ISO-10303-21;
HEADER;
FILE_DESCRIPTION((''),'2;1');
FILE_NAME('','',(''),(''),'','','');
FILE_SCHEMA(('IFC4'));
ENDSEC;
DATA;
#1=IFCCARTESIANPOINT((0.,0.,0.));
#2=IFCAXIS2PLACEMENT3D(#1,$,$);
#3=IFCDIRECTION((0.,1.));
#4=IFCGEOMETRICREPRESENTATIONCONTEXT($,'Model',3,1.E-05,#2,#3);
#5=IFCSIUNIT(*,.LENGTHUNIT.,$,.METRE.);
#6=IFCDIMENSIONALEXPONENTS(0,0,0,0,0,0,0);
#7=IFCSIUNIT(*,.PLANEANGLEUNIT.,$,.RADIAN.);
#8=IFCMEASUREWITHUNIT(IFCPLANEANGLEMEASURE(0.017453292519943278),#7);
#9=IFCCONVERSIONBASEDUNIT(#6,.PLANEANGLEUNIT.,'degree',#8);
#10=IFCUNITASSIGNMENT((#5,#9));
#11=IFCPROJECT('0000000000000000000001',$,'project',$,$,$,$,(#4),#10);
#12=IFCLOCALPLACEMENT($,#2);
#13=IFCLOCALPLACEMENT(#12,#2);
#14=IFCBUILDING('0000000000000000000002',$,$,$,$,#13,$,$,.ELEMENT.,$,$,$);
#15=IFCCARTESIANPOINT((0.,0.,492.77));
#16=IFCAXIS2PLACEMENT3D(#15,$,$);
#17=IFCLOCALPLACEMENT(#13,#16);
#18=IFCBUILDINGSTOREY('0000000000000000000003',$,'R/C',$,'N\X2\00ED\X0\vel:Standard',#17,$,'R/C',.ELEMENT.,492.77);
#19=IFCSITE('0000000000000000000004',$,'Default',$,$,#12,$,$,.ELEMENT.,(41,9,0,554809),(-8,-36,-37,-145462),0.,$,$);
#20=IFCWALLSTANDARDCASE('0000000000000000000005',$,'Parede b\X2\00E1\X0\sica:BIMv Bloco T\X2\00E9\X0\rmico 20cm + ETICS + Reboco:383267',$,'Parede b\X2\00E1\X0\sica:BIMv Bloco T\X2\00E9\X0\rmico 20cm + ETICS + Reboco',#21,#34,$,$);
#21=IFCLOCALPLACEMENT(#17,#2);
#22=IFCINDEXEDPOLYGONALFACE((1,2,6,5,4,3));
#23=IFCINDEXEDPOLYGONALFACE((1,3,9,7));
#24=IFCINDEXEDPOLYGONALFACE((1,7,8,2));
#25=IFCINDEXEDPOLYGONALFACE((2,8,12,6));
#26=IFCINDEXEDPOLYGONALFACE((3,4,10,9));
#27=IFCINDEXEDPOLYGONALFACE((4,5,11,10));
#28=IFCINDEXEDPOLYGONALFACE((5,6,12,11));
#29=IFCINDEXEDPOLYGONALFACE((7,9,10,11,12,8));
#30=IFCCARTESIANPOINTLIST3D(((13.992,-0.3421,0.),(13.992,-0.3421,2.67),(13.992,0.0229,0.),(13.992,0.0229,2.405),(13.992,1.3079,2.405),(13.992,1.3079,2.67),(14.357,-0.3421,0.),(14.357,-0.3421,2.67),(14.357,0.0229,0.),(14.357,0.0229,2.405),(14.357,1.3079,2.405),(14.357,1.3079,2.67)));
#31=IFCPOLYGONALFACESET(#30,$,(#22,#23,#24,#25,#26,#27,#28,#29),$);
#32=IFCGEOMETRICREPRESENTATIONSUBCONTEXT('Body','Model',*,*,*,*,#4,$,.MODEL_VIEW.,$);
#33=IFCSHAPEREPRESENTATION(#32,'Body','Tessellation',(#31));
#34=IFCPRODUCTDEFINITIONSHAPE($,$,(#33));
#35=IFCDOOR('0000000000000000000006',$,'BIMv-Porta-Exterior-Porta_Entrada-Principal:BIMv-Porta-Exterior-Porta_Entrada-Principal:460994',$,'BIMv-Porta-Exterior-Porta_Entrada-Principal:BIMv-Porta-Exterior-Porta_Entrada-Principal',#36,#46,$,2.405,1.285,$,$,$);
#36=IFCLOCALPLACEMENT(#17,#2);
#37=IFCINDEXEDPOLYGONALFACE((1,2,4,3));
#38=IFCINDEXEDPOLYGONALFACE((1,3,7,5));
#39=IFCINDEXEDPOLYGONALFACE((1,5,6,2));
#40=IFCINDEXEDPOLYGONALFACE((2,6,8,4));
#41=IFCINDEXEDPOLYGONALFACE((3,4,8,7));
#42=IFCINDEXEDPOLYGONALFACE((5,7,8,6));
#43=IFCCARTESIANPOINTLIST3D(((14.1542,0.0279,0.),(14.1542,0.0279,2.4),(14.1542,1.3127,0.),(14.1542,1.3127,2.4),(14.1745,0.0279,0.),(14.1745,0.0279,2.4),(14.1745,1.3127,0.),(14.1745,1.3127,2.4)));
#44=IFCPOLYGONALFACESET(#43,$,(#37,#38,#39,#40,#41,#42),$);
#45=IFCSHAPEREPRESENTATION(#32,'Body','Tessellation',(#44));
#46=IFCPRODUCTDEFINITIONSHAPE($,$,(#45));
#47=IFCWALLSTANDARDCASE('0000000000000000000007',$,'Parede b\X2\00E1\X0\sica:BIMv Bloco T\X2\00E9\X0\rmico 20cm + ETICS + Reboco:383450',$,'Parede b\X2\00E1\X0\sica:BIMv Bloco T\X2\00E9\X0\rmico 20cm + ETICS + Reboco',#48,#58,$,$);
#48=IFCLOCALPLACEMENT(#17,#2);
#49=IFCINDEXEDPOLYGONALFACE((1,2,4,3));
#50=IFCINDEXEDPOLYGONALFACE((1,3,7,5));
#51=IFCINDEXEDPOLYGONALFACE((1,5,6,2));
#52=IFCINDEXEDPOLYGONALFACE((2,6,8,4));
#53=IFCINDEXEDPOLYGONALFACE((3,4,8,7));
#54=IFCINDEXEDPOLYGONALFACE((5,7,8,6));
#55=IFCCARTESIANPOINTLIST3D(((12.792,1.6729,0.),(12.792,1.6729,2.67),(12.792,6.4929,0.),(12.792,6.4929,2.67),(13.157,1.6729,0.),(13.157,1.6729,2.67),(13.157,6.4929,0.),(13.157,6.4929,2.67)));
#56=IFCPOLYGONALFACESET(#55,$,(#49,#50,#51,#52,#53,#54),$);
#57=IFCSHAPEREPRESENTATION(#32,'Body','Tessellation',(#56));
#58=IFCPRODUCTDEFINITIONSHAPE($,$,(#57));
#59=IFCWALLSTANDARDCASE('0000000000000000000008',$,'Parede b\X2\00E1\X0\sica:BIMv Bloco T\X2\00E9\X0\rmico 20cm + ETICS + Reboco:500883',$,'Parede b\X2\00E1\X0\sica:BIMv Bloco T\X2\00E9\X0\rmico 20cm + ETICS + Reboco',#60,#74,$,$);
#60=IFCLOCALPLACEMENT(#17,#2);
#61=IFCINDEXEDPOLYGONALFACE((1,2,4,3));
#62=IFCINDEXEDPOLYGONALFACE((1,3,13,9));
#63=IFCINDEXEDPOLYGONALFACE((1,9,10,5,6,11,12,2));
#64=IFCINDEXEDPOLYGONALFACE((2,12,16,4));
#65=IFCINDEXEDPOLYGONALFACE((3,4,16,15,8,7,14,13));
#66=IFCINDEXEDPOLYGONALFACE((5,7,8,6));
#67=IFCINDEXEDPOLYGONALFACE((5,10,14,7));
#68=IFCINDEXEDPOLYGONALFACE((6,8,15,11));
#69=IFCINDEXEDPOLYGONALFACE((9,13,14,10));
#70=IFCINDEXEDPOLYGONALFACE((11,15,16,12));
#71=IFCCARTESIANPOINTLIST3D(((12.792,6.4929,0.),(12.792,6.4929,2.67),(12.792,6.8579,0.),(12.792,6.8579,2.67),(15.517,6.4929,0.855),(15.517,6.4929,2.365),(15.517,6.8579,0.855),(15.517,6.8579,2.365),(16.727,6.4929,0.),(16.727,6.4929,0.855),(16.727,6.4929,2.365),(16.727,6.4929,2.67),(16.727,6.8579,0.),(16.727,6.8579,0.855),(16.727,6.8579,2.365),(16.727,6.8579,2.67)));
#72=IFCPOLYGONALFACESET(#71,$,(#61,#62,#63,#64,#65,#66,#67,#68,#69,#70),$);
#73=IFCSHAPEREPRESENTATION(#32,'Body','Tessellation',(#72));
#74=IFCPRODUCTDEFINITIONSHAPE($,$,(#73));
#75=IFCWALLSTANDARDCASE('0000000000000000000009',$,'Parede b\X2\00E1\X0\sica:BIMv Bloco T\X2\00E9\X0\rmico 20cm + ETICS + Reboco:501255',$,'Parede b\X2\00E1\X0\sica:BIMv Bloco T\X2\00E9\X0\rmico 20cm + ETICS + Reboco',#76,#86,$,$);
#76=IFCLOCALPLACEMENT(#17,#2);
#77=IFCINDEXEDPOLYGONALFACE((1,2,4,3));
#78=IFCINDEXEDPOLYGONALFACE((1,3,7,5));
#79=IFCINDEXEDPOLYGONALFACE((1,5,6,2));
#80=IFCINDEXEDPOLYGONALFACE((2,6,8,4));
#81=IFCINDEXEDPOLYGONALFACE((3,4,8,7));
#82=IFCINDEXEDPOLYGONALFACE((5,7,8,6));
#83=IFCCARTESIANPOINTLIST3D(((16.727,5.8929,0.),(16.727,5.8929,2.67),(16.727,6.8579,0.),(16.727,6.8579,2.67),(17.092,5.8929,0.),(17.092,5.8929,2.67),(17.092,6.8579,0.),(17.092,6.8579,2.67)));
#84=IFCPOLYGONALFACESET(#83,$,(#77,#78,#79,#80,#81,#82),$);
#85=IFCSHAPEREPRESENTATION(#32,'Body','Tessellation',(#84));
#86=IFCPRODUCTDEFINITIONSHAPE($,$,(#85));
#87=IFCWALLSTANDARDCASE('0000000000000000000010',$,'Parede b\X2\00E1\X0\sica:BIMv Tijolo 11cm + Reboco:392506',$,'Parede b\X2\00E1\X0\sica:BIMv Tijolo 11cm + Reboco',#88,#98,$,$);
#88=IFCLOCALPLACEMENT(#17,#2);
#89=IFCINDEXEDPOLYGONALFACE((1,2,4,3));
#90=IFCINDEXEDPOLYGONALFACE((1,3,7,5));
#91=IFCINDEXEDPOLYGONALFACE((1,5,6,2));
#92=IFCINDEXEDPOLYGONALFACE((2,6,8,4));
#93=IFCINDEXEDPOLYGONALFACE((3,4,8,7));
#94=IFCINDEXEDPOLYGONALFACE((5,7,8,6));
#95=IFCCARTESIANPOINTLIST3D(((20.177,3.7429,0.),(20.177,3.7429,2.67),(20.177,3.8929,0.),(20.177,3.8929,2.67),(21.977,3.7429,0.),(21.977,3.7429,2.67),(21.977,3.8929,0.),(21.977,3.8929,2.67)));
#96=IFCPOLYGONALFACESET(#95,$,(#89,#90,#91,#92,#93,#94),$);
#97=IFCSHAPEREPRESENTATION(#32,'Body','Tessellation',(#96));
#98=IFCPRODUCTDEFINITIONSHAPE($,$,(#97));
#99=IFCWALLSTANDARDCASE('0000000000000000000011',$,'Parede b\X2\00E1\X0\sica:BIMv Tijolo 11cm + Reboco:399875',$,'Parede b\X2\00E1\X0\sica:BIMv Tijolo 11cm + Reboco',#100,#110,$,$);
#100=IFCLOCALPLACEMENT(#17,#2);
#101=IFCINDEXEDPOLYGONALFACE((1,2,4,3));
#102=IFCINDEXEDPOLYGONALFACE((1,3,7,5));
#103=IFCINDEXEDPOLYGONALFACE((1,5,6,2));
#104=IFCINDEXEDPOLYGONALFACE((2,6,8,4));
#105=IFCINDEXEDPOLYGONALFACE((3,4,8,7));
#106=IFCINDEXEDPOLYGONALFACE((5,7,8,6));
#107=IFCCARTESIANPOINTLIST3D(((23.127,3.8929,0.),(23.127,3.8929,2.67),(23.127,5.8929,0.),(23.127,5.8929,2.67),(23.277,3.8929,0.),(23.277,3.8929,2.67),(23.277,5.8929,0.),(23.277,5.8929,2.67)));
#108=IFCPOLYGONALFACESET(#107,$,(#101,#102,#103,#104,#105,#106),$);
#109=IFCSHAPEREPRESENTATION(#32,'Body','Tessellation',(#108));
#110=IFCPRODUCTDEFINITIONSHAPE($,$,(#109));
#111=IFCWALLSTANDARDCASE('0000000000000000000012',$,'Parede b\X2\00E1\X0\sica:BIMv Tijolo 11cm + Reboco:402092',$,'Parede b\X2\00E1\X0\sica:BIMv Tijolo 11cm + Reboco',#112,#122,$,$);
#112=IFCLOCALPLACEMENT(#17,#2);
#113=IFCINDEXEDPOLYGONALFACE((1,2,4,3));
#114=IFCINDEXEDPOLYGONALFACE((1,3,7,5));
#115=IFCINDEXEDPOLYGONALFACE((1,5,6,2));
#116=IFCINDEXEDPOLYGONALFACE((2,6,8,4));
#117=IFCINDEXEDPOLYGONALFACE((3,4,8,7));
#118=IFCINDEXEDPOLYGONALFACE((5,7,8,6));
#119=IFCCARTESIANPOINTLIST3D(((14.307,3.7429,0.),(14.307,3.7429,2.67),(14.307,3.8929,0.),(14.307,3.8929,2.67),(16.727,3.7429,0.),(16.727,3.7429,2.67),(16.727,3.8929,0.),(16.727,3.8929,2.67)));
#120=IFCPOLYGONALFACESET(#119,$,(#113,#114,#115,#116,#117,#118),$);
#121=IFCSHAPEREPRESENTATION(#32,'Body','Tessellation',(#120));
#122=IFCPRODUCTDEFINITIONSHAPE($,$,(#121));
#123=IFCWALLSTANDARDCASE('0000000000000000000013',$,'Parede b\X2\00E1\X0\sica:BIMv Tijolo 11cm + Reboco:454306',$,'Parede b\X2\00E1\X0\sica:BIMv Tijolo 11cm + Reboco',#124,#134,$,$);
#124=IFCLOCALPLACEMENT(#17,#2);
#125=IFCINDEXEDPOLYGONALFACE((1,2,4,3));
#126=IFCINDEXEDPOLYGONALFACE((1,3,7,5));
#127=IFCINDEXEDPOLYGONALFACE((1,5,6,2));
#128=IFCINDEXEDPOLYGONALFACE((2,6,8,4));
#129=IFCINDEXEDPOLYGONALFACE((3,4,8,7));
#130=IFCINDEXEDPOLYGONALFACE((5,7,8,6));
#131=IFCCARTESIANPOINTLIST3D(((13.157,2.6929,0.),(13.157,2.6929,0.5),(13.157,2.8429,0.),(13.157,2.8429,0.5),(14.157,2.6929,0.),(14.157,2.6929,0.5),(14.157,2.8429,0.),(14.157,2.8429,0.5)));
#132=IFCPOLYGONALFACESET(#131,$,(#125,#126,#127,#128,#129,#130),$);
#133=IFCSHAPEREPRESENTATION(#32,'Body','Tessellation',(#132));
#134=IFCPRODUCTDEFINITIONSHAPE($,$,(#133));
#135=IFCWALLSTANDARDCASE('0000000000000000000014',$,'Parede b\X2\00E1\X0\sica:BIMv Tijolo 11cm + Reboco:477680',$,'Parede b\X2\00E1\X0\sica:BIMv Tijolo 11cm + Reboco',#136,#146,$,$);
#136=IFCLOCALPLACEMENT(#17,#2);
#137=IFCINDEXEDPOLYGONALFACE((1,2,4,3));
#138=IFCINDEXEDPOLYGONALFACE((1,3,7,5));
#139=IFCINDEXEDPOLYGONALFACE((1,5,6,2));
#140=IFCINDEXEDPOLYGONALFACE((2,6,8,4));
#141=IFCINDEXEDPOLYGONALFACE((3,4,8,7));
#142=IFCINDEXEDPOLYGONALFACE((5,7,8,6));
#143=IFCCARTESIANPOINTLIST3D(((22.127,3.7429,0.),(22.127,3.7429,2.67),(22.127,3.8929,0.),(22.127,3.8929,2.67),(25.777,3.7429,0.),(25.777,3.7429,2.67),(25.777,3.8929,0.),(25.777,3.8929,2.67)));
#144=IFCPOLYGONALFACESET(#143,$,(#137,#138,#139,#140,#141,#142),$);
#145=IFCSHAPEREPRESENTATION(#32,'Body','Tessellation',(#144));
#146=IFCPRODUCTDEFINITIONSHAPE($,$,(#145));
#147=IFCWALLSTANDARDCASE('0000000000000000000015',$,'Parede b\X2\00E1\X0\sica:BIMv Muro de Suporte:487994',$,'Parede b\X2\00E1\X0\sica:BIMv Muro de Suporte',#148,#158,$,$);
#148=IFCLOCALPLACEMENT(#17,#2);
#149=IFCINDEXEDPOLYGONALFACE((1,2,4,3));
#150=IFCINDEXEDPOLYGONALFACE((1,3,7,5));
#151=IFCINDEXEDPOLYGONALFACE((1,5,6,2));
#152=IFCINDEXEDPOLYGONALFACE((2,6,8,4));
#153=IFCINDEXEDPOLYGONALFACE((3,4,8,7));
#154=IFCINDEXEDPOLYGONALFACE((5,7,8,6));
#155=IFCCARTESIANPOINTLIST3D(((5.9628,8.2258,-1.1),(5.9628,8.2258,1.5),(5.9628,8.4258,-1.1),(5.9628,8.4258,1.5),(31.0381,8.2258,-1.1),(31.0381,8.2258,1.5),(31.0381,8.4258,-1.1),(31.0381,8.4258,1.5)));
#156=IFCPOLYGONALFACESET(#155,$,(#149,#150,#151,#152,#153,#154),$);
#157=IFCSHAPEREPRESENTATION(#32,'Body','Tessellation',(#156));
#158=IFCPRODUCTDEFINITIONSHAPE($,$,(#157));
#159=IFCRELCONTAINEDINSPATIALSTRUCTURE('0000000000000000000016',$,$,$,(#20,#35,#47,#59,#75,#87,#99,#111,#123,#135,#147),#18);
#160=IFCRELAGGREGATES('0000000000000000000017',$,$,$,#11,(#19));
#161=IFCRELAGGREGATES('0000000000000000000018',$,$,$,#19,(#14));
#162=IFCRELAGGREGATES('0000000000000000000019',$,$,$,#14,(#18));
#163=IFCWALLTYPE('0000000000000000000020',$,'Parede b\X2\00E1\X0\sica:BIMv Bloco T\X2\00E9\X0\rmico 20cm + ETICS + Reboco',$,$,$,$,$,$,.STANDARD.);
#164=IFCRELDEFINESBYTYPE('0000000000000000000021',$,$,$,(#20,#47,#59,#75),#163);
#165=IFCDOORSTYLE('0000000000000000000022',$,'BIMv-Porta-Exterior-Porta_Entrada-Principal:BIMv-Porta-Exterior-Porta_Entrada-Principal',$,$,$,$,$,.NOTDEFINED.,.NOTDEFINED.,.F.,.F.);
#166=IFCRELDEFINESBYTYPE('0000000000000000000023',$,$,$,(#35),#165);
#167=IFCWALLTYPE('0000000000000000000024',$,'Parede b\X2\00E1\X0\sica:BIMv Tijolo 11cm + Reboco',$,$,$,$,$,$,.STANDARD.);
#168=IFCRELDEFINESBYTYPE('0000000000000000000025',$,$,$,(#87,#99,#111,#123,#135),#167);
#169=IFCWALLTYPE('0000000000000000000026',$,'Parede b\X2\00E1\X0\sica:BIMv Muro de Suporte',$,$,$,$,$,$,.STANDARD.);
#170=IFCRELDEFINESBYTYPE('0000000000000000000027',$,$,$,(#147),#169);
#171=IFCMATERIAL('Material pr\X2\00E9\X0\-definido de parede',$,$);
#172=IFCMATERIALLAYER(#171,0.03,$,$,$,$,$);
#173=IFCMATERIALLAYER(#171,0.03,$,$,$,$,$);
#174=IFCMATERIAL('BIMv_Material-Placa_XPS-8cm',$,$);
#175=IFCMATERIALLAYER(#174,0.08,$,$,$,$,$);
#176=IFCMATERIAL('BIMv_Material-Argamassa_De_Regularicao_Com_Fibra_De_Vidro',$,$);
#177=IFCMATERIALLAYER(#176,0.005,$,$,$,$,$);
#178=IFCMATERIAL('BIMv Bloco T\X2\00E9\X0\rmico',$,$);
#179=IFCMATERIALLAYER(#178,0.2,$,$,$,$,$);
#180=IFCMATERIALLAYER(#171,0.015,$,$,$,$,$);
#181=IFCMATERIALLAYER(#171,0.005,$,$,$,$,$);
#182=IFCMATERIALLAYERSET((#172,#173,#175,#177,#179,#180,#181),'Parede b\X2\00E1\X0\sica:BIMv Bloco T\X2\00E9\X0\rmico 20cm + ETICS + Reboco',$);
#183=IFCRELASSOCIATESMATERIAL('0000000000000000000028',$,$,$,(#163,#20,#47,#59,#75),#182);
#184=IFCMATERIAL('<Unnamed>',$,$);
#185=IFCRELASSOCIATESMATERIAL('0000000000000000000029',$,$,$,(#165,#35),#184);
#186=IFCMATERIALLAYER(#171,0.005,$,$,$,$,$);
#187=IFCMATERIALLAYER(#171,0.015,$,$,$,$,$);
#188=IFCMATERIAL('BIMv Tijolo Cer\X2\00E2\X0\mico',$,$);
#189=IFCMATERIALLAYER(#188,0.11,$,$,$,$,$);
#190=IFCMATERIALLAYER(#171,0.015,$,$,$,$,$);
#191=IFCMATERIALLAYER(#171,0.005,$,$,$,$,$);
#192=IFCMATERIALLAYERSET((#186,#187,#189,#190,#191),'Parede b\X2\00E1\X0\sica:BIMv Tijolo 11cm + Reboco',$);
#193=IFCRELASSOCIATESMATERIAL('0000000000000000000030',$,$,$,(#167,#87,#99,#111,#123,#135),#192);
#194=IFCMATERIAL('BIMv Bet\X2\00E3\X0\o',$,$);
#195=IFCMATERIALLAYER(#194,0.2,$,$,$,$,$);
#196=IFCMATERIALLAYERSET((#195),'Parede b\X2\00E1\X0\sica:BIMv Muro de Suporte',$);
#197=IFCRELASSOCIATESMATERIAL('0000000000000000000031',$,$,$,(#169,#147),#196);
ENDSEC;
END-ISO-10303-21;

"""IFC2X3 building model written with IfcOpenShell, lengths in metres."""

from ifc_helpers import new_model, entity, si_unit, converted_unit, direction, frame, frame_2d, origin, place, context, subcontext, project, spatial, polyline, rectangle, extrude, clip, bounded_halfspace, source, transform, mapped, material, layer, layer_set, layer_usage, type_object, type_shapes, element, fill, save


model = new_model("IFC2X3")

# Units and contexts
model_context = context("Model", 3, precision=1e-05, world=origin(), true_north=direction((0.0, 1.0)))
body_context = subcontext(model_context, "Body", "Model", "MODEL_VIEW")
ifc_project = project(units=[si_unit("LENGTHUNIT", "METRE"), converted_unit("PLANEANGLEUNIT", "degree", entity("IfcPlaneAngleMeasure", 0.017453292519943278), si_unit("PLANEANGLEUNIT", "RADIAN"), dimensions=[0, 0, 0, 0, 0, 0, 0])], contexts=[model_context])

# Site, building, storey
site_placement = place(None, origin())
site = spatial("IfcSite", under=ifc_project, at=site_placement, Name="Default", CompositionType="ELEMENT", RefLatitude=(41, 9, 0, 554809), RefLongitude=(-8, -36, -37, -145462), RefElevation=0.0)
building_placement = place(site_placement, origin())
building = spatial("IfcBuilding", under=site, at=building_placement, CompositionType="ELEMENT")
storey_placement = place(building_placement, frame((0.0, 0.0, 492.77)))
storey = spatial("IfcBuildingStorey", under=building, at=storey_placement, Name="R/C", ObjectType="Nível:Standard", LongName="R/C", CompositionType="ELEMENT", Elevation=492.77)

# Shared definitions
ifc_material_1 = material(Name="Material pré-definido de parede")
ifc_layer_1 = layer(ifc_material_1, 0.03)
ifc_layer_2 = layer(ifc_material_1, 0.03)
ifc_material_2 = material(Name="BIMv_Material-Placa_XPS-8cm")
ifc_layer_3 = layer(ifc_material_2, 0.08)
ifc_material_3 = material(Name="BIMv_Material-Argamassa_De_Regularicao_Com_Fibra_De_Vidro")
ifc_layer_4 = layer(ifc_material_3, 0.005)
ifc_material_4 = material(Name="BIMv Bloco Térmico")
ifc_layer_5 = layer(ifc_material_4, 0.2)
ifc_layer_6 = layer(ifc_material_1, 0.015)
ifc_layer_7 = layer(ifc_material_1, 0.005)
ifc_layer_set_1 = layer_set([ifc_layer_1, ifc_layer_2, ifc_layer_3, ifc_layer_4, ifc_layer_5, ifc_layer_6, ifc_layer_7], Name="Parede básica:BIMv Bloco Térmico 20cm + ETICS + Reboco")
wall_type_1 = type_object("IfcWallType", Name="Parede básica:BIMv Bloco Térmico 20cm + ETICS + Reboco", PredefinedType="STANDARD", material=ifc_layer_set_1)

# Wall, opening, door
ifc_layer_usage_1 = layer_usage(ifc_layer_set_1, "AXIS2", "POSITIVE", -0.1825)
wall_1_placement = place(storey_placement, frame((14.1745, 1.3079, 0.0), z_axis=(0.0, 0.0, 1.0), x_axis=(0.0, -1.0, 0.0)))
wall_1 = element("IfcWallStandardCase", 1, at=wall_1_placement, inside=storey, type_object=wall_type_1, material=ifc_layer_usage_1, Name="Parede básica:BIMv Bloco Térmico 20cm + ETICS + Reboco:383267", ObjectType="Parede básica:BIMv Bloco Térmico 20cm + ETICS + Reboco", context=body_context, shape_type="SweptSolid", body=[
    extrude(rectangle(XDim=1.65, YDim=0.365, at=frame_2d((0.825, 0.0), x_axis=(1.0, 0.0))), origin(), (0.0, 0.0, 1.0), 2.67),
])
opening_1_placement = place(wall_1_placement, frame((0.0, -0.1825, 0.0)))
opening_1 = element("IfcOpeningElement", 2, at=opening_1_placement, cuts=wall_1, ObjectType="Opening", context=body_context, shape_type="SweptSolid", body=[
    extrude(rectangle(XDim=2.405, YDim=1.285, at=frame_2d((1.2025, 0.6425), x_axis=(1.0, 0.0))), frame((0.0, 0.0, 0.0), z_axis=(0.0, 1.0, 0.0), x_axis=(0.0, 0.0, 1.0)), (0.0, 0.0, 1.0), 0.365),
])
ifc_material_5 = material(Name="<Unnamed>")
door_style = type_object("IfcDoorStyle", Name="BIMv-Porta-Exterior-Porta_Entrada-Principal:BIMv-Porta-Exterior-Porta_Entrada-Principal", ConstructionType="NOTDEFINED", OperationType="NOTDEFINED", ParameterTakesPrecedence=False, Sizeable=False, material=ifc_material_5)
shared_shape_1 = source(origin(), body_context, "Body", "SweptSolid", [
    extrude(rectangle(XDim=1.2848, YDim=0.0204, at=frame_2d((0.0, 0.0), x_axis=(1.0, 0.0))), frame((0.6376, 0.1723, 0.0), z_axis=(0.0, 0.0, 1.0), x_axis=(-1.0, 0.0, 0.0)), (0.0, 0.0, 1.0), 2.4),
])
type_shapes(door_style, [shared_shape_1])
door_placement = place(opening_1_placement, origin())
door = element("IfcDoor", 3, at=door_placement, inside=storey, type_object=door_style, material=ifc_material_5, Name="BIMv-Porta-Exterior-Porta_Entrada-Principal:BIMv-Porta-Exterior-Porta_Entrada-Principal:460994", ObjectType="BIMv-Porta-Exterior-Porta_Entrada-Principal:BIMv-Porta-Exterior-Porta_Entrada-Principal", OverallHeight=2.405, OverallWidth=1.285, context=body_context, shape_type="MappedRepresentation", body=[
    mapped(shared_shape_1, transform((0.0, 0.0, 0.0), scale=1.0)),
])
fill(opening_1, door)

# Wall
ifc_layer_usage_2 = layer_usage(ifc_layer_set_1, "AXIS2", "NEGATIVE", 0.1825)
wall_2_placement = place(storey_placement, frame((12.9745, 1.6729, 0.0), z_axis=(0.0, 0.0, 1.0), x_axis=(0.0, 1.0, 0.0)))
element("IfcWallStandardCase", 4, at=wall_2_placement, inside=storey, type_object=wall_type_1, material=ifc_layer_usage_2, Name="Parede básica:BIMv Bloco Térmico 20cm + ETICS + Reboco:383450", ObjectType="Parede básica:BIMv Bloco Térmico 20cm + ETICS + Reboco", context=body_context, shape_type="SweptSolid", body=[
    extrude(rectangle(XDim=4.82, YDim=0.365, at=frame_2d((2.41, 0.0), x_axis=(1.0, 0.0))), origin(), (0.0, 0.0, 1.0), 2.67),
])

# Wall, opening
ifc_layer_usage_3 = layer_usage(ifc_layer_set_1, "AXIS2", "NEGATIVE", 0.1825)
wall_3_placement = place(storey_placement, frame((12.792, 6.6754, 0.0)))
wall_3 = element("IfcWallStandardCase", 5, at=wall_3_placement, inside=storey, type_object=wall_type_1, material=ifc_layer_usage_3, Name="Parede básica:BIMv Bloco Térmico 20cm + ETICS + Reboco:500883", ObjectType="Parede básica:BIMv Bloco Térmico 20cm + ETICS + Reboco", context=body_context, shape_type="SweptSolid", body=[
    extrude(rectangle(XDim=3.935, YDim=0.365, at=frame_2d((1.9675, 0.0), x_axis=(1.0, 0.0))), origin(), (0.0, 0.0, 1.0), 2.67),
])
opening_2_placement = place(wall_3_placement, frame((2.725, -0.1825, 0.855)))
element("IfcOpeningElement", 6, at=opening_2_placement, cuts=wall_3, ObjectType="Opening", context=body_context, shape_type="SweptSolid", body=[
    extrude(rectangle(XDim=1.51, YDim=1.21, at=frame_2d((0.755, 0.605), x_axis=(-1.0, 0.0))), frame((0.0, 0.0, 0.0), z_axis=(0.0, 1.0, 0.0), x_axis=(0.0, 0.0, 1.0)), (0.0, 0.0, 1.0), 0.365),
])

# Walls
ifc_layer_usage_4 = layer_usage(ifc_layer_set_1, "AXIS2", "NEGATIVE", 0.1825)
wall_4_placement = place(storey_placement, frame((16.9095, 6.8579, 0.0), z_axis=(0.0, 0.0, 1.0), x_axis=(0.0, -1.0, 0.0)))
element("IfcWallStandardCase", 7, at=wall_4_placement, inside=storey, type_object=wall_type_1, material=ifc_layer_usage_4, Name="Parede básica:BIMv Bloco Térmico 20cm + ETICS + Reboco:501255", ObjectType="Parede básica:BIMv Bloco Térmico 20cm + ETICS + Reboco", context=body_context, shape_type="SweptSolid", body=[
    extrude(rectangle(XDim=0.965, YDim=0.365, at=frame_2d((0.4825, 0.0), x_axis=(1.0, 0.0))), origin(), (0.0, 0.0, 1.0), 2.67),
])
ifc_layer_8 = layer(ifc_material_1, 0.005)
ifc_layer_9 = layer(ifc_material_1, 0.015)
ifc_material_6 = material(Name="BIMv Tijolo Cerâmico")
ifc_layer_10 = layer(ifc_material_6, 0.11)
ifc_layer_11 = layer(ifc_material_1, 0.015)
ifc_layer_12 = layer(ifc_material_1, 0.005)
ifc_layer_set_2 = layer_set([ifc_layer_8, ifc_layer_9, ifc_layer_10, ifc_layer_11, ifc_layer_12], Name="Parede básica:BIMv Tijolo 11cm + Reboco")
ifc_layer_usage_5 = layer_usage(ifc_layer_set_2, "AXIS2", "NEGATIVE", 0.075)
wall_type_2 = type_object("IfcWallType", Name="Parede básica:BIMv Tijolo 11cm + Reboco", PredefinedType="STANDARD", material=ifc_layer_set_2)
wall_5_placement = place(storey_placement, frame((20.177, 3.8179, 0.0)))
element("IfcWallStandardCase", 8, at=wall_5_placement, inside=storey, type_object=wall_type_2, material=ifc_layer_usage_5, Name="Parede básica:BIMv Tijolo 11cm + Reboco:392506", ObjectType="Parede básica:BIMv Tijolo 11cm + Reboco", context=body_context, shape_type="Clipping", body=[
    clip(extrude(rectangle(XDim=1.8, YDim=0.15, at=frame_2d((0.9, 0.0), x_axis=(1.0, 0.0))), origin(), (0.0, 0.0, 1.0), 2.67), bounded_halfspace(frame((0.0, -0.075, 2.67), z_axis=(0.0, 0.0, -1.0), x_axis=(0.0, -1.0, 0.0)), True, frame((0.0, -0.075, 2.67)), polyline([(0.0, 0.0), (1.8, 0.0), (1.8, 0.15), (0.0, 0.15), (0.0, 0.0)]))),
])
ifc_layer_usage_6 = layer_usage(ifc_layer_set_2, "AXIS2", "NEGATIVE", 0.075)
wall_6_placement = place(storey_placement, frame((23.202, 3.8929, 0.0), z_axis=(0.0, 0.0, 1.0), x_axis=(0.0, 1.0, 0.0)))
element("IfcWallStandardCase", 9, at=wall_6_placement, inside=storey, type_object=wall_type_2, material=ifc_layer_usage_6, Name="Parede básica:BIMv Tijolo 11cm + Reboco:399875", ObjectType="Parede básica:BIMv Tijolo 11cm + Reboco", context=body_context, shape_type="Clipping", body=[
    clip(extrude(rectangle(XDim=2.0, YDim=0.15, at=frame_2d((1.0, 0.0), x_axis=(1.0, 0.0))), origin(), (0.0, 0.0, 1.0), 2.67), bounded_halfspace(frame((0.0, -0.075, 2.67), z_axis=(0.0, 0.0, -1.0), x_axis=(-1.0, 0.0, 0.0)), True, frame((0.0, -0.075, 2.67)), polyline([(0.0, 0.0), (2.0, 0.0), (2.0, 0.15), (0.0, 0.15), (0.0, 0.0)]))),
])
ifc_layer_usage_7 = layer_usage(ifc_layer_set_2, "AXIS2", "NEGATIVE", 0.075)
wall_7_placement = place(storey_placement, frame((16.727, 3.8179, 0.0), z_axis=(0.0, 0.0, 1.0), x_axis=(-1.0, 0.0, 0.0)))
element("IfcWallStandardCase", 10, at=wall_7_placement, inside=storey, type_object=wall_type_2, material=ifc_layer_usage_7, Name="Parede básica:BIMv Tijolo 11cm + Reboco:402092", ObjectType="Parede básica:BIMv Tijolo 11cm + Reboco", context=body_context, shape_type="SweptSolid", body=[
    extrude(rectangle(XDim=2.42, YDim=0.15, at=frame_2d((1.21, 0.0), x_axis=(1.0, 0.0))), origin(), (0.0, 0.0, 1.0), 2.67),
])
ifc_layer_usage_8 = layer_usage(ifc_layer_set_2, "AXIS2", "NEGATIVE", 0.075)
wall_8_placement = place(storey_placement, frame((14.157, 2.7679, 0.0), z_axis=(0.0, 0.0, 1.0), x_axis=(-1.0, 0.0, 0.0)))
element("IfcWallStandardCase", 11, at=wall_8_placement, inside=storey, type_object=wall_type_2, material=ifc_layer_usage_8, Name="Parede básica:BIMv Tijolo 11cm + Reboco:454306", ObjectType="Parede básica:BIMv Tijolo 11cm + Reboco", context=body_context, shape_type="SweptSolid", body=[
    extrude(rectangle(XDim=1.0, YDim=0.15, at=frame_2d((0.5, 0.0), x_axis=(1.0, 0.0))), origin(), (0.0, 0.0, 1.0), 0.5),
])
ifc_layer_usage_9 = layer_usage(ifc_layer_set_2, "AXIS2", "POSITIVE", -0.075)
wall_9_placement = place(storey_placement, frame((22.127, 3.8179, 0.0)))
element("IfcWallStandardCase", 12, at=wall_9_placement, inside=storey, type_object=wall_type_2, material=ifc_layer_usage_9, Name="Parede básica:BIMv Tijolo 11cm + Reboco:477680", ObjectType="Parede básica:BIMv Tijolo 11cm + Reboco", context=body_context, shape_type="Clipping", body=[
    clip(extrude(rectangle(XDim=3.65, YDim=0.15, at=frame_2d((1.825, 0.0), x_axis=(1.0, 0.0))), origin(), (0.0, 0.0, 1.0), 2.67), bounded_halfspace(frame((0.0, -0.075, 2.67), z_axis=(0.0, 0.0, -1.0), x_axis=(0.0, -1.0, 0.0)), True, frame((0.0, -0.075, 2.67)), polyline([(0.0, 0.0), (2.15, 0.0), (2.3, 0.0), (3.65, 0.0), (3.65, 0.15), (1.15, 0.15), (1.0, 0.15), (0.0, 0.15), (0.0, 0.0)]))),
])
ifc_material_7 = material(Name="BIMv Betão")
ifc_layer_13 = layer(ifc_material_7, 0.2)
ifc_layer_set_3 = layer_set([ifc_layer_13], Name="Parede básica:BIMv Muro de Suporte")
ifc_layer_usage_10 = layer_usage(ifc_layer_set_3, "AXIS2", "NEGATIVE", 0.1)
wall_type_3 = type_object("IfcWallType", Name="Parede básica:BIMv Muro de Suporte", PredefinedType="STANDARD", material=ifc_layer_set_3)
wall_10_placement = place(storey_placement, frame((5.9628, 8.3258, -1.1)))
element("IfcWallStandardCase", 13, at=wall_10_placement, inside=storey, type_object=wall_type_3, material=ifc_layer_usage_10, Name="Parede básica:BIMv Muro de Suporte:487994", ObjectType="Parede básica:BIMv Muro de Suporte", context=body_context, shape_type="SweptSolid", body=[
    extrude(rectangle(XDim=25.0753, YDim=0.2, at=frame_2d((12.5376, 0.0), x_axis=(-1.0, 0.0))), origin(), (0.0, 0.0, 1.0), 2.6),
])

save(model, "model.ifc")
